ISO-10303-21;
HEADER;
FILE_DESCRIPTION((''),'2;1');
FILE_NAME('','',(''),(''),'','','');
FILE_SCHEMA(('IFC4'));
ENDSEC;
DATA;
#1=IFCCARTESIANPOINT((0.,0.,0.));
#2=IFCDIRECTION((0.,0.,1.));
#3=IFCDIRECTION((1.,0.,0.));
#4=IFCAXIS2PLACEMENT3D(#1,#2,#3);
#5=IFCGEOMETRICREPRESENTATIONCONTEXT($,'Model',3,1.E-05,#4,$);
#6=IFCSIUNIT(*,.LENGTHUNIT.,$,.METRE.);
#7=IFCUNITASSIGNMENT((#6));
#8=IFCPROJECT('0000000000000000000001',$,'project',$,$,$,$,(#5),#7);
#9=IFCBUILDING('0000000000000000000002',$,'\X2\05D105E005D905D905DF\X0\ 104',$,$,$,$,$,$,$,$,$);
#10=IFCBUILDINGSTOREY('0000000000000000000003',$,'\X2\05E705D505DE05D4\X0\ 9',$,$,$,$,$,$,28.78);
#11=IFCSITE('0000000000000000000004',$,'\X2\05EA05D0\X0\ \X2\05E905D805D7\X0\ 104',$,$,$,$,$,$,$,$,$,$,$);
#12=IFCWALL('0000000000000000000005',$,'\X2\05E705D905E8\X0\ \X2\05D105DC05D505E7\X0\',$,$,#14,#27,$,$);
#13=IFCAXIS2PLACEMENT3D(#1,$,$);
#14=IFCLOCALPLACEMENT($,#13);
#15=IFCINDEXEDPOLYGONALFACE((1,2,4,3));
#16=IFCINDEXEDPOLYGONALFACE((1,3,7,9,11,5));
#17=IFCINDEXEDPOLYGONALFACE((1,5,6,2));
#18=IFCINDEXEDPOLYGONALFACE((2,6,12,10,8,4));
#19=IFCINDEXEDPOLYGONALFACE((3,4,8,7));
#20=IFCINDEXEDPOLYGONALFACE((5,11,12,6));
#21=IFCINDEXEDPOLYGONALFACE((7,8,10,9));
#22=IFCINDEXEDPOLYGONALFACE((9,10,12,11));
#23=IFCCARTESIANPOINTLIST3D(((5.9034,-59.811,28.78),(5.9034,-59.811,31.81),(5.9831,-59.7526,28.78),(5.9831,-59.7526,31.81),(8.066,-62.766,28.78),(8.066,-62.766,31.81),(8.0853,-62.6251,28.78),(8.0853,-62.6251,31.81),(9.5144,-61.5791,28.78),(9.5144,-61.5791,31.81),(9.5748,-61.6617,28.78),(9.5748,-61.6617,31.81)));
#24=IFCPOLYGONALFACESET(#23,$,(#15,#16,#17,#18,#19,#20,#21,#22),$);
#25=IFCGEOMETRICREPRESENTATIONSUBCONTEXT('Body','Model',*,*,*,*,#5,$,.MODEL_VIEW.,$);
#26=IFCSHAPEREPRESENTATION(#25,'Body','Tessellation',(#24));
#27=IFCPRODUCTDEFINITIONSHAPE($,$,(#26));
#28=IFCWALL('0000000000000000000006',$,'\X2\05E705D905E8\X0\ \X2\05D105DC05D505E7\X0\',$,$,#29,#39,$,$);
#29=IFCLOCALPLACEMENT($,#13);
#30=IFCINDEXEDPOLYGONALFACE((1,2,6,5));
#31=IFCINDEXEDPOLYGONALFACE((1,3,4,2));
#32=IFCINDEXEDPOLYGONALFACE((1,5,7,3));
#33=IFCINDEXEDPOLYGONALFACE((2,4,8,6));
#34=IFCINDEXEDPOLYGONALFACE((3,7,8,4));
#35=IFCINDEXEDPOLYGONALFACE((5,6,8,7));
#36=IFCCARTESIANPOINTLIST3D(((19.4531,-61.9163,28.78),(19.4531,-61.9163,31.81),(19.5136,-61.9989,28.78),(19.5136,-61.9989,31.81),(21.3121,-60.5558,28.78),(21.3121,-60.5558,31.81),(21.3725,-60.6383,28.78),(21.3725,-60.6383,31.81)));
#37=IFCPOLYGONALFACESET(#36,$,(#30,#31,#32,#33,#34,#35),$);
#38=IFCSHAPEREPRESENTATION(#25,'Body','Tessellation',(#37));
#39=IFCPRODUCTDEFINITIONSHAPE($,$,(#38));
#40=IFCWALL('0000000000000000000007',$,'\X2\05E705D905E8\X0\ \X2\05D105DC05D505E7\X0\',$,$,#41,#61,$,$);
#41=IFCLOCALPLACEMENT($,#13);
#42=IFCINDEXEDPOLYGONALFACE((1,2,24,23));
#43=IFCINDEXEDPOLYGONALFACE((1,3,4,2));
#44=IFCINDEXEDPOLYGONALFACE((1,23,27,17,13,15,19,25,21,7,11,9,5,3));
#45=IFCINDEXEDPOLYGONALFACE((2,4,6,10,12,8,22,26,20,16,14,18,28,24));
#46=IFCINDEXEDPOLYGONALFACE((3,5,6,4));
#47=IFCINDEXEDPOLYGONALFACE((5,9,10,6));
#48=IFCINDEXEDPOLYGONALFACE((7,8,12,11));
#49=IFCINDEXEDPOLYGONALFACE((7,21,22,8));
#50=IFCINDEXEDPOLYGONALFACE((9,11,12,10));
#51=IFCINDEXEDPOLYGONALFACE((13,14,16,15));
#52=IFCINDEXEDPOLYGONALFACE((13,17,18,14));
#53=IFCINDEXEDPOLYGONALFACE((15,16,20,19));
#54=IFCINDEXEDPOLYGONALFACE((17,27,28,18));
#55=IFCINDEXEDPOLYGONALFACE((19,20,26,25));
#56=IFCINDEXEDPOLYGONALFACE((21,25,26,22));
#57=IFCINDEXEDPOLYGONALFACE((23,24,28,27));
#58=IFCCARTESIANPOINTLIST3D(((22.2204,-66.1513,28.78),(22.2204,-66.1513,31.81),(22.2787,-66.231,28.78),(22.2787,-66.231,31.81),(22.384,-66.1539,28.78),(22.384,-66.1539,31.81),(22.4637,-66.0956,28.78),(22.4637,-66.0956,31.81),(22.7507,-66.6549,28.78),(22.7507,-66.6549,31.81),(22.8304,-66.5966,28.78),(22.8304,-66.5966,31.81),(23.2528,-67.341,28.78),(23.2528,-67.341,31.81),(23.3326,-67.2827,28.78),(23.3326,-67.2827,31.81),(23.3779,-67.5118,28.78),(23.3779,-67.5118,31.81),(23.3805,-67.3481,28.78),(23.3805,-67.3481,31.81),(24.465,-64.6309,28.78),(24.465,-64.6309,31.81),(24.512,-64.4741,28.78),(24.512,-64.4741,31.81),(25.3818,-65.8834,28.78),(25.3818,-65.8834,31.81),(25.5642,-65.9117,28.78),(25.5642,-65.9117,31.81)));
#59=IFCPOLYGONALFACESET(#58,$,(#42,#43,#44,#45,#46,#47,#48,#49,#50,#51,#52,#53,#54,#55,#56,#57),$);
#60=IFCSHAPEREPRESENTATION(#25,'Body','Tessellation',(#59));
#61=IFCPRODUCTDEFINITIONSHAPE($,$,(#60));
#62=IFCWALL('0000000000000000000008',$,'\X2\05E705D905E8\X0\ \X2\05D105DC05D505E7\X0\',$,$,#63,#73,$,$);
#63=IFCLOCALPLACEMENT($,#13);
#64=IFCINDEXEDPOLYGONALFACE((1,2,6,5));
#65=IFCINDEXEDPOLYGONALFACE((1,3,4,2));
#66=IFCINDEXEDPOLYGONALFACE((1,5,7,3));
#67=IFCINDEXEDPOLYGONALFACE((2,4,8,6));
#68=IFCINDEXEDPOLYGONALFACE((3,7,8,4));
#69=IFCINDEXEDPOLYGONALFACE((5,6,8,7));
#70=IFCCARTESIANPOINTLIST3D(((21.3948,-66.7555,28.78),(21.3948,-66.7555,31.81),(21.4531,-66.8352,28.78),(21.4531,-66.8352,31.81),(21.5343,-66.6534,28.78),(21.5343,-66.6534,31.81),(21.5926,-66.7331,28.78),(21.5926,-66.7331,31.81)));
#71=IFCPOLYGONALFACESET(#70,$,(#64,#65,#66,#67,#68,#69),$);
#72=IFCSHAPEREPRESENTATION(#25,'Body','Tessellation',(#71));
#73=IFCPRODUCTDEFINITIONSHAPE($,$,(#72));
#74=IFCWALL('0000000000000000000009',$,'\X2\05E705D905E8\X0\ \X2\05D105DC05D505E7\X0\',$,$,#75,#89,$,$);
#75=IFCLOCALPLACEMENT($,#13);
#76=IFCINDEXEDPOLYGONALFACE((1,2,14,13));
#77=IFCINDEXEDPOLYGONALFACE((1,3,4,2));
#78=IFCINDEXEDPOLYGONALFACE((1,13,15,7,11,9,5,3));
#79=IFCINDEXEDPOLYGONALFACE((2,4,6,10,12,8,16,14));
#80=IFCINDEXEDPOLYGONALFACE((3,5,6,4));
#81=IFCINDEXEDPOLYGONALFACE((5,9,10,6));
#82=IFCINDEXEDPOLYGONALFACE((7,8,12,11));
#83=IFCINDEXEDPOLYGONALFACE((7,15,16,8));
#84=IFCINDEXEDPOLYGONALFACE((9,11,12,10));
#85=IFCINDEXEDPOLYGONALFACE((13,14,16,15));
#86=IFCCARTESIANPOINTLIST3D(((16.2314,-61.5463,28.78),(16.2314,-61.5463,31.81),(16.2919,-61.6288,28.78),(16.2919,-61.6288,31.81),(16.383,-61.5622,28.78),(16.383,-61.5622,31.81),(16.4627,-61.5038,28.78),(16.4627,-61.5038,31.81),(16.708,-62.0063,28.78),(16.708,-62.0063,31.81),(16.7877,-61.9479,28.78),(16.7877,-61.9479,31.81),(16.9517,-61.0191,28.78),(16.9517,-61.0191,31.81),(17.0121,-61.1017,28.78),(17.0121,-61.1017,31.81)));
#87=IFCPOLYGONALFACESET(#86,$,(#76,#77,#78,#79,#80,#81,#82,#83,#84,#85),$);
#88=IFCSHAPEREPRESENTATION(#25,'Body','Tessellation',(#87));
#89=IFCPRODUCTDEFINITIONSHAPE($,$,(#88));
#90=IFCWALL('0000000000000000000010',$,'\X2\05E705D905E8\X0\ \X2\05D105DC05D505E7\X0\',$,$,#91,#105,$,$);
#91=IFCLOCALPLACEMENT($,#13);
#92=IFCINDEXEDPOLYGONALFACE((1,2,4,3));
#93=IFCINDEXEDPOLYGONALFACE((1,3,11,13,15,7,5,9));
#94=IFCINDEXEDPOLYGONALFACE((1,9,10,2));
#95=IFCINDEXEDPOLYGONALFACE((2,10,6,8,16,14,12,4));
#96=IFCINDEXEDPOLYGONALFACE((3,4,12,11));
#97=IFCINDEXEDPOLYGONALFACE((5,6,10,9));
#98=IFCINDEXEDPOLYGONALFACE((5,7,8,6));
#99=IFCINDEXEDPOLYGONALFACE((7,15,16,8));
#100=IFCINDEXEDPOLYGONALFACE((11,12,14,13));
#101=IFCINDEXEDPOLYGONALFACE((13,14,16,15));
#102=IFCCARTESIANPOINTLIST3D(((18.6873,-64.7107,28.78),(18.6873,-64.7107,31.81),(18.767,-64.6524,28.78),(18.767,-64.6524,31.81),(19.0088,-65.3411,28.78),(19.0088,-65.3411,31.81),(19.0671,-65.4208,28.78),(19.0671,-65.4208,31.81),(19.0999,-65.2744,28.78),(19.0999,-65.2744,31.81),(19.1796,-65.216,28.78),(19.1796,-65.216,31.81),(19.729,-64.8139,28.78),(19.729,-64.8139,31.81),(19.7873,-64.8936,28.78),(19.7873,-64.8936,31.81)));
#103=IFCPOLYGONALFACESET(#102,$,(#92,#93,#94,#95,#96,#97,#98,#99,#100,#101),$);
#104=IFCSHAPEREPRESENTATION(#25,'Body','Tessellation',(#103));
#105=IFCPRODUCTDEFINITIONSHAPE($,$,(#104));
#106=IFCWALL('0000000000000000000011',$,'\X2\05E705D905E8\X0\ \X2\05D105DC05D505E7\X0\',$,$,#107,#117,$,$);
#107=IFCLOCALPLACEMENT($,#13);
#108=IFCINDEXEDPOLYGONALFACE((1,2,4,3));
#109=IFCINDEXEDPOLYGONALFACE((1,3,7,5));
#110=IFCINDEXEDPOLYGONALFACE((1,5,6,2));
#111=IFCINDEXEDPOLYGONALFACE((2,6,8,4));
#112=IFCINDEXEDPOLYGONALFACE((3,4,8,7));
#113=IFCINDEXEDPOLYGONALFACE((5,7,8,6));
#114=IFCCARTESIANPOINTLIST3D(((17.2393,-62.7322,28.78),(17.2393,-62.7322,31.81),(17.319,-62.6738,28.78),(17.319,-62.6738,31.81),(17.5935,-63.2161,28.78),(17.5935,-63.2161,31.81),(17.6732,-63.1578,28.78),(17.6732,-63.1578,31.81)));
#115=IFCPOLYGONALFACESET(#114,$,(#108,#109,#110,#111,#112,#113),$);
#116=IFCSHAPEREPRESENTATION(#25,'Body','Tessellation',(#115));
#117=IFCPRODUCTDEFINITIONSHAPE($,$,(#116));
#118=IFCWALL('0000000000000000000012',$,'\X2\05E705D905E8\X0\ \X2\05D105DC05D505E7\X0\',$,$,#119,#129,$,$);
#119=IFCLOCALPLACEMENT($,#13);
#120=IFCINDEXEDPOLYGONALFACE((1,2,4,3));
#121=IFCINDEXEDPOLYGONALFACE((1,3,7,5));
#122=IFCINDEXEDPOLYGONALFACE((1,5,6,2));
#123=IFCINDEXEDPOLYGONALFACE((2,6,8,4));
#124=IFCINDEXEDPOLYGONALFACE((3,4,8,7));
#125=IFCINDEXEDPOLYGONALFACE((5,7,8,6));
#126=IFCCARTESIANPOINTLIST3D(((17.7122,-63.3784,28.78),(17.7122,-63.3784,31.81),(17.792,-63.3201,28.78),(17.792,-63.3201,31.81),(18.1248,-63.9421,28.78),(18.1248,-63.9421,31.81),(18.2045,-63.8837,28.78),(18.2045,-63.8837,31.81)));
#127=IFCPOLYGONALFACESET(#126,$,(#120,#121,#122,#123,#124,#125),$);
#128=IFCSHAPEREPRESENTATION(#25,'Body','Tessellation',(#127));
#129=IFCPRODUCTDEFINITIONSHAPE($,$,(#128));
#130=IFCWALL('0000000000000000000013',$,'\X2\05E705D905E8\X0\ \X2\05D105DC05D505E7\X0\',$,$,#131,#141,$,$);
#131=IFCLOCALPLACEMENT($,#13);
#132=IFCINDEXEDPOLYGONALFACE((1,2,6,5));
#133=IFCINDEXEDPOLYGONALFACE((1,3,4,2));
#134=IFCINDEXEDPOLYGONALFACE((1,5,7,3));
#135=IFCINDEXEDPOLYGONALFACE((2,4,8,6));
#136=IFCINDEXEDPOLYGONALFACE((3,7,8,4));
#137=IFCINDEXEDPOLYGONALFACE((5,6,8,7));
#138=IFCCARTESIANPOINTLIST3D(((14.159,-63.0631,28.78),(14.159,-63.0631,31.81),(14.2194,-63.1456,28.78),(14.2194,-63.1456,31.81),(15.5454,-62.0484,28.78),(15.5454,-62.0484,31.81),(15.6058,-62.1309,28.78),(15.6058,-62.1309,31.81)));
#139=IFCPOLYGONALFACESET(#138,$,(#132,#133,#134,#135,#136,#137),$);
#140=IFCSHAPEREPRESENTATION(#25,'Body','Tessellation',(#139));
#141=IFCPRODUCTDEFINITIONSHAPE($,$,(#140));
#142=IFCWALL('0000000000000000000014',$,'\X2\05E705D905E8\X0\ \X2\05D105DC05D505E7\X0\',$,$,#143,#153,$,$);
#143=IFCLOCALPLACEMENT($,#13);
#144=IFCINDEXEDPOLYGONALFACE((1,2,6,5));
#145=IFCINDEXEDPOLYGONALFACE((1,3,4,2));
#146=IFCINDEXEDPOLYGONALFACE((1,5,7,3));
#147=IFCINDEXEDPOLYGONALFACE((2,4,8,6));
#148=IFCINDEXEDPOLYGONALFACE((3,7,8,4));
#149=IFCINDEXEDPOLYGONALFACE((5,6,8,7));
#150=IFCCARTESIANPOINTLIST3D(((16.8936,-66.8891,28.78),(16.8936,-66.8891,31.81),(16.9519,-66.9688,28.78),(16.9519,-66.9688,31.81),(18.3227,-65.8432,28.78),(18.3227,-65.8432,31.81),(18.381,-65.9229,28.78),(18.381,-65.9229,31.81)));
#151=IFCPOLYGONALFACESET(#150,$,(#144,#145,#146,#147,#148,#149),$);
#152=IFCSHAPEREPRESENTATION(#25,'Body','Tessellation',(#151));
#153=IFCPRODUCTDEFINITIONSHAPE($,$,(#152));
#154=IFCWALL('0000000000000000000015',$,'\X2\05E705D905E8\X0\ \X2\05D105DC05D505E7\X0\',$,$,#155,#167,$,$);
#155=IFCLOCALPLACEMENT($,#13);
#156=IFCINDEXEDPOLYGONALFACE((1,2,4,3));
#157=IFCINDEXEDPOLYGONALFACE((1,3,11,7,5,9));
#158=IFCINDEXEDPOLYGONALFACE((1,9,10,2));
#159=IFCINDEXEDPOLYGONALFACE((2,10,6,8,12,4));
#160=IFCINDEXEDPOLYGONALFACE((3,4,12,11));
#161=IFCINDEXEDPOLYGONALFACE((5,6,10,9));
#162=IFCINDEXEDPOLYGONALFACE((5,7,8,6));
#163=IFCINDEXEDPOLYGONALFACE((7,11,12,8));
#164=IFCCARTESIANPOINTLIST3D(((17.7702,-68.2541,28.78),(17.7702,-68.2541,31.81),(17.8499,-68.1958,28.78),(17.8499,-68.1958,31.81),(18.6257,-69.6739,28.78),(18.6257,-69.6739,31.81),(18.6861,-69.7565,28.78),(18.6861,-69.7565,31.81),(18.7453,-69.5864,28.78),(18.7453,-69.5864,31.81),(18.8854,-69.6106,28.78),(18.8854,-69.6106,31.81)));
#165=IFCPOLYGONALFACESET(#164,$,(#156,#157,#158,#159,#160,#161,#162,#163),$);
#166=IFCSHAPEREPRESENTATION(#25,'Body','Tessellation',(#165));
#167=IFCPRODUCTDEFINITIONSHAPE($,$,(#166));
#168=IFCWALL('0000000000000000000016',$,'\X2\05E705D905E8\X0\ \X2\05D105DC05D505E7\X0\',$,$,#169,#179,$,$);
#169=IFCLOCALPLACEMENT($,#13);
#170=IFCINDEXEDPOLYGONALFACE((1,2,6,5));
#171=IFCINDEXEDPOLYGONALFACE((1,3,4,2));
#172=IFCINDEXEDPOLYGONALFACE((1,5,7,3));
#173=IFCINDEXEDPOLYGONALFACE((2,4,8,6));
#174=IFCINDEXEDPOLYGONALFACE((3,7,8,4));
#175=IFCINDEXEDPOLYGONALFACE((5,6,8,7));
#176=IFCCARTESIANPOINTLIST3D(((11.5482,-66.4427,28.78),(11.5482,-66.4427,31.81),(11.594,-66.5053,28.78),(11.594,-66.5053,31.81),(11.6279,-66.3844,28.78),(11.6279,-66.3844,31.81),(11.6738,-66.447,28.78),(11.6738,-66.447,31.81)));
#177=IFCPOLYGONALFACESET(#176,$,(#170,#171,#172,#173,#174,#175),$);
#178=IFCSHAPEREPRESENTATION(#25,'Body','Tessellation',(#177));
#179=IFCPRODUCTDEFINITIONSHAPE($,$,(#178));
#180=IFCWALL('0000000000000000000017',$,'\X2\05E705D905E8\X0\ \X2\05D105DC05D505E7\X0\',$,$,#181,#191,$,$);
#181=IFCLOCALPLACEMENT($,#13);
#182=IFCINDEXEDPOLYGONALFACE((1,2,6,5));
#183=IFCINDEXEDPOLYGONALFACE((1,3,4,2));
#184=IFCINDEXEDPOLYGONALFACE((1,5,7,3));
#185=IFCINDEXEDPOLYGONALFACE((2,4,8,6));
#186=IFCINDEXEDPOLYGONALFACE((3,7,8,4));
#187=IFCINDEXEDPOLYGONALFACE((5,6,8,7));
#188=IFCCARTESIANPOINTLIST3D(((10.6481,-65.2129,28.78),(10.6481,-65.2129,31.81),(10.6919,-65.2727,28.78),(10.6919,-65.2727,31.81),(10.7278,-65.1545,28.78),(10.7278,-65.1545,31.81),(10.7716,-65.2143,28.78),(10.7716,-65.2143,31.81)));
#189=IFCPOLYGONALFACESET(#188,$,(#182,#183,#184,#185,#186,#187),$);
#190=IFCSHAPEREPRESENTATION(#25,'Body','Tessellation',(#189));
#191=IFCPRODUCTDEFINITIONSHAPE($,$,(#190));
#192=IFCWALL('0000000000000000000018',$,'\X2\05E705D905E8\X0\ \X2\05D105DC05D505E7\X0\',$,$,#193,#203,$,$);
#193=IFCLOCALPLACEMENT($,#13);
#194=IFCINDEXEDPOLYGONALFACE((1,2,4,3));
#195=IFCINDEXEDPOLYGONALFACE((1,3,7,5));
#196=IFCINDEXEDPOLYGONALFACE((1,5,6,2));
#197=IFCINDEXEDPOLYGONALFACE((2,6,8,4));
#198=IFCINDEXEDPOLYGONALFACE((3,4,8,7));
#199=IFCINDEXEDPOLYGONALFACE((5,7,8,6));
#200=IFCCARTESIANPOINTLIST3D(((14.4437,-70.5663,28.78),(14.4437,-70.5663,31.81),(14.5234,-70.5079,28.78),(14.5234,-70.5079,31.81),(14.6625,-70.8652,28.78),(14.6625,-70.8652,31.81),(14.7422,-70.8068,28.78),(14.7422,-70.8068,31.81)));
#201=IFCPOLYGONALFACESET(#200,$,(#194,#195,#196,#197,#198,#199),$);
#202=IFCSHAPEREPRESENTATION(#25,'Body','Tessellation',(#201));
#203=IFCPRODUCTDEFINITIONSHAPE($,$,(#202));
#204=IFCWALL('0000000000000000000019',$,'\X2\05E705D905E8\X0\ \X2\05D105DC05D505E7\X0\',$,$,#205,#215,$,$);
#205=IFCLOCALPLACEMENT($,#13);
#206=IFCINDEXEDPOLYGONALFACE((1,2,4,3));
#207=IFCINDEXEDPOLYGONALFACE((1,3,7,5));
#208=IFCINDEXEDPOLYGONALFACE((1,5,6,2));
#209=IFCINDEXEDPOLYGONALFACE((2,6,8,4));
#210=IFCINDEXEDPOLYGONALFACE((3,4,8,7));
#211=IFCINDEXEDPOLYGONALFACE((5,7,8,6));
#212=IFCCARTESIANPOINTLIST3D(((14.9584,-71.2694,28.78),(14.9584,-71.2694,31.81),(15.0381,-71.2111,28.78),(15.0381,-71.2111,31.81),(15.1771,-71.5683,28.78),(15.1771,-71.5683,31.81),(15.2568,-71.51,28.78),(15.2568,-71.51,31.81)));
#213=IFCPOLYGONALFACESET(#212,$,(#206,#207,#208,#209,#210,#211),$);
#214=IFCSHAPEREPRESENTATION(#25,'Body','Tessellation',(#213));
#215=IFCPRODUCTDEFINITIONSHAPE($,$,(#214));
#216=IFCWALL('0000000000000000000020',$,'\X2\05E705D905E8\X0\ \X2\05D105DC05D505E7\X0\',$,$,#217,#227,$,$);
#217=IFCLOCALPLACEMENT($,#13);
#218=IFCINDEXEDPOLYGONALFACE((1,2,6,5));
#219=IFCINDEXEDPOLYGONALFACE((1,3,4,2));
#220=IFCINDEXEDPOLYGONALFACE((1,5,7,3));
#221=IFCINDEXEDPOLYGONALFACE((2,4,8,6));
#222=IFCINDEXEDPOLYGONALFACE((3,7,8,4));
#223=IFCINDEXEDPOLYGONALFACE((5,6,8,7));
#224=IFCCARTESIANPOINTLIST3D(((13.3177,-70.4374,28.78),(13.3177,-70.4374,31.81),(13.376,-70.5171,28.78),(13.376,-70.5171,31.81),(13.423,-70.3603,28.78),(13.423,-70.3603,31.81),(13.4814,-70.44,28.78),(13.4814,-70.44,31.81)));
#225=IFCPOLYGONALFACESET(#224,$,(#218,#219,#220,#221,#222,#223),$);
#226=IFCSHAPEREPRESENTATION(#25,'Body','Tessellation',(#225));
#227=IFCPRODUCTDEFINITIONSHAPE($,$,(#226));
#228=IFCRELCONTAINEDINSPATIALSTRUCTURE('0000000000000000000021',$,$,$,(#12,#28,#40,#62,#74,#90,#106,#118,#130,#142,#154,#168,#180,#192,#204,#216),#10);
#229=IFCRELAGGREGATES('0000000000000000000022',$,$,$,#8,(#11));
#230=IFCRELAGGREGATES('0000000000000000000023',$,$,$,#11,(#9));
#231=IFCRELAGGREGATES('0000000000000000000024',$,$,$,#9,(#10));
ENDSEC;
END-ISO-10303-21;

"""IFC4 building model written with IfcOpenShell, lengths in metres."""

from ifc_helpers import new_model, si_unit, frame, origin_with_axes, context, subcontext, project, spatial, polyline, outline, extrude, element, save


model = new_model("IFC4")

# Units and contexts
model_context = context("Model", 3, precision=1e-05, world=origin_with_axes())
body_context = subcontext(model_context, "Body", "Model", "MODEL_VIEW")
ifc_project = project(units=[si_unit("LENGTHUNIT", "METRE")], contexts=[model_context])

# Site, building, storey
site = spatial("IfcSite", under=ifc_project, Name="תא שטח 104")
building = spatial("IfcBuilding", under=site, Name="בניין 104")
storey = spatial("IfcBuildingStorey", under=building, Name="קומה 9", Elevation=28.78)

# Walls
element("IfcWall", 1, inside=storey, Name="קיר בלוק", context=body_context, shape_type="SweptSolid", body=[
    extrude(outline(polyline([(5.9034, -59.811), (8.066, -62.766), (9.5748, -61.6617), (9.5144, -61.5791), (8.0853, -62.6251), (5.9831, -59.7526), (5.9034, -59.811)])), frame((0.0, 0.0, 28.78)), (0.0, 0.0, 1.0), 3.03),
])
element("IfcWall", 2, inside=storey, Name="קיר בלוק", context=body_context, shape_type="SweptSolid", body=[
    extrude(outline(polyline([(21.3725, -60.6383), (21.3121, -60.5558), (19.4531, -61.9163), (19.5136, -61.9989), (21.3725, -60.6383)])), frame((0.0, 0.0, 28.78)), (0.0, 0.0, 1.0), 3.03),
])
element("IfcWall", 3, inside=storey, Name="קיר בלוק", context=body_context, shape_type="SweptSolid", body=[
    extrude(outline(polyline([(22.384, -66.1539), (22.7507, -66.6549), (22.8304, -66.5966), (22.4637, -66.0956), (24.465, -64.6309), (25.3818, -65.8834), (23.3805, -67.3481), (23.3326, -67.2827), (23.2528, -67.341), (23.3779, -67.5118), (25.5642, -65.9117), (24.512, -64.4741), (22.2204, -66.1513), (22.2787, -66.231), (22.384, -66.1539)])), frame((0.0, 0.0, 28.78)), (0.0, 0.0, 1.0), 3.03),
])
element("IfcWall", 4, inside=storey, Name="קיר בלוק", context=body_context, shape_type="SweptSolid", body=[
    extrude(outline(polyline([(21.4531, -66.8352), (21.5926, -66.7331), (21.5343, -66.6534), (21.3948, -66.7555), (21.4531, -66.8352)])), frame((0.0, 0.0, 28.78)), (0.0, 0.0, 1.0), 3.03),
])
element("IfcWall", 5, inside=storey, Name="קיר בלוק", context=body_context, shape_type="SweptSolid", body=[
    extrude(outline(polyline([(16.2919, -61.6288), (16.383, -61.5622), (16.708, -62.0063), (16.7877, -61.9479), (16.4627, -61.5038), (17.0121, -61.1017), (16.9517, -61.0191), (16.2314, -61.5463), (16.2919, -61.6288)])), frame((0.0, 0.0, 28.78)), (0.0, 0.0, 1.0), 3.03),
])
element("IfcWall", 6, inside=storey, Name="קיר בלוק", context=body_context, shape_type="SweptSolid", body=[
    extrude(outline(polyline([(19.0999, -65.2744), (19.0088, -65.3411), (19.0671, -65.4208), (19.7873, -64.8936), (19.729, -64.8139), (19.1796, -65.216), (18.767, -64.6524), (18.6873, -64.7107), (19.0999, -65.2744)])), frame((0.0, 0.0, 28.78)), (0.0, 0.0, 1.0), 3.03),
])
element("IfcWall", 7, inside=storey, Name="קיר בלוק", context=body_context, shape_type="SweptSolid", body=[
    extrude(outline(polyline([(17.6732, -63.1578), (17.319, -62.6738), (17.2393, -62.7322), (17.5935, -63.2161), (17.6732, -63.1578)])), frame((0.0, 0.0, 28.78)), (0.0, 0.0, 1.0), 3.03),
])
element("IfcWall", 8, inside=storey, Name="קיר בלוק", context=body_context, shape_type="SweptSolid", body=[
    extrude(outline(polyline([(18.1248, -63.9421), (18.2045, -63.8837), (17.792, -63.3201), (17.7122, -63.3784), (18.1248, -63.9421)])), frame((0.0, 0.0, 28.78)), (0.0, 0.0, 1.0), 3.03),
])
element("IfcWall", 9, inside=storey, Name="קיר בלוק", context=body_context, shape_type="SweptSolid", body=[
    extrude(outline(polyline([(14.159, -63.0631), (14.2194, -63.1456), (15.6058, -62.1309), (15.5454, -62.0484), (14.159, -63.0631)])), frame((0.0, 0.0, 28.78)), (0.0, 0.0, 1.0), 3.03),
])
element("IfcWall", 10, inside=storey, Name="קיר בלוק", context=body_context, shape_type="SweptSolid", body=[
    extrude(outline(polyline([(18.381, -65.9229), (18.3227, -65.8432), (16.8936, -66.8891), (16.9519, -66.9688), (18.381, -65.9229)])), frame((0.0, 0.0, 28.78)), (0.0, 0.0, 1.0), 3.03),
])
element("IfcWall", 11, inside=storey, Name="קיר בלוק", context=body_context, shape_type="SweptSolid", body=[
    extrude(outline(polyline([(18.7453, -69.5864), (18.6257, -69.6739), (18.6861, -69.7565), (18.8854, -69.6106), (17.8499, -68.1958), (17.7702, -68.2541), (18.7453, -69.5864)])), frame((0.0, 0.0, 28.78)), (0.0, 0.0, 1.0), 3.03),
])
element("IfcWall", 12, inside=storey, Name="קיר בלוק", context=body_context, shape_type="SweptSolid", body=[
    extrude(outline(polyline([(11.594, -66.5053), (11.6738, -66.447), (11.6279, -66.3844), (11.5482, -66.4427), (11.594, -66.5053)])), frame((0.0, 0.0, 28.78)), (0.0, 0.0, 1.0), 3.03),
])
element("IfcWall", 13, inside=storey, Name="קיר בלוק", context=body_context, shape_type="SweptSolid", body=[
    extrude(outline(polyline([(10.7278, -65.1545), (10.6481, -65.2129), (10.6919, -65.2727), (10.7716, -65.2143), (10.7278, -65.1545)])), frame((0.0, 0.0, 28.78)), (0.0, 0.0, 1.0), 3.03),
])
element("IfcWall", 14, inside=storey, Name="קיר בלוק", context=body_context, shape_type="SweptSolid", body=[
    extrude(outline(polyline([(14.6625, -70.8652), (14.7422, -70.8068), (14.5234, -70.5079), (14.4437, -70.5663), (14.6625, -70.8652)])), frame((0.0, 0.0, 28.78)), (0.0, 0.0, 1.0), 3.03),
])
element("IfcWall", 15, inside=storey, Name="קיר בלוק", context=body_context, shape_type="SweptSolid", body=[
    extrude(outline(polyline([(15.2568, -71.51), (15.0381, -71.2111), (14.9584, -71.2694), (15.1771, -71.5683), (15.2568, -71.51)])), frame((0.0, 0.0, 28.78)), (0.0, 0.0, 1.0), 3.03),
])
element("IfcWall", 16, inside=storey, Name="קיר בלוק", context=body_context, shape_type="SweptSolid", body=[
    extrude(outline(polyline([(13.376, -70.5171), (13.4814, -70.44), (13.423, -70.3603), (13.3177, -70.4374), (13.376, -70.5171)])), frame((0.0, 0.0, 28.78)), (0.0, 0.0, 1.0), 3.03),
])

save(model, "model.ifc")
